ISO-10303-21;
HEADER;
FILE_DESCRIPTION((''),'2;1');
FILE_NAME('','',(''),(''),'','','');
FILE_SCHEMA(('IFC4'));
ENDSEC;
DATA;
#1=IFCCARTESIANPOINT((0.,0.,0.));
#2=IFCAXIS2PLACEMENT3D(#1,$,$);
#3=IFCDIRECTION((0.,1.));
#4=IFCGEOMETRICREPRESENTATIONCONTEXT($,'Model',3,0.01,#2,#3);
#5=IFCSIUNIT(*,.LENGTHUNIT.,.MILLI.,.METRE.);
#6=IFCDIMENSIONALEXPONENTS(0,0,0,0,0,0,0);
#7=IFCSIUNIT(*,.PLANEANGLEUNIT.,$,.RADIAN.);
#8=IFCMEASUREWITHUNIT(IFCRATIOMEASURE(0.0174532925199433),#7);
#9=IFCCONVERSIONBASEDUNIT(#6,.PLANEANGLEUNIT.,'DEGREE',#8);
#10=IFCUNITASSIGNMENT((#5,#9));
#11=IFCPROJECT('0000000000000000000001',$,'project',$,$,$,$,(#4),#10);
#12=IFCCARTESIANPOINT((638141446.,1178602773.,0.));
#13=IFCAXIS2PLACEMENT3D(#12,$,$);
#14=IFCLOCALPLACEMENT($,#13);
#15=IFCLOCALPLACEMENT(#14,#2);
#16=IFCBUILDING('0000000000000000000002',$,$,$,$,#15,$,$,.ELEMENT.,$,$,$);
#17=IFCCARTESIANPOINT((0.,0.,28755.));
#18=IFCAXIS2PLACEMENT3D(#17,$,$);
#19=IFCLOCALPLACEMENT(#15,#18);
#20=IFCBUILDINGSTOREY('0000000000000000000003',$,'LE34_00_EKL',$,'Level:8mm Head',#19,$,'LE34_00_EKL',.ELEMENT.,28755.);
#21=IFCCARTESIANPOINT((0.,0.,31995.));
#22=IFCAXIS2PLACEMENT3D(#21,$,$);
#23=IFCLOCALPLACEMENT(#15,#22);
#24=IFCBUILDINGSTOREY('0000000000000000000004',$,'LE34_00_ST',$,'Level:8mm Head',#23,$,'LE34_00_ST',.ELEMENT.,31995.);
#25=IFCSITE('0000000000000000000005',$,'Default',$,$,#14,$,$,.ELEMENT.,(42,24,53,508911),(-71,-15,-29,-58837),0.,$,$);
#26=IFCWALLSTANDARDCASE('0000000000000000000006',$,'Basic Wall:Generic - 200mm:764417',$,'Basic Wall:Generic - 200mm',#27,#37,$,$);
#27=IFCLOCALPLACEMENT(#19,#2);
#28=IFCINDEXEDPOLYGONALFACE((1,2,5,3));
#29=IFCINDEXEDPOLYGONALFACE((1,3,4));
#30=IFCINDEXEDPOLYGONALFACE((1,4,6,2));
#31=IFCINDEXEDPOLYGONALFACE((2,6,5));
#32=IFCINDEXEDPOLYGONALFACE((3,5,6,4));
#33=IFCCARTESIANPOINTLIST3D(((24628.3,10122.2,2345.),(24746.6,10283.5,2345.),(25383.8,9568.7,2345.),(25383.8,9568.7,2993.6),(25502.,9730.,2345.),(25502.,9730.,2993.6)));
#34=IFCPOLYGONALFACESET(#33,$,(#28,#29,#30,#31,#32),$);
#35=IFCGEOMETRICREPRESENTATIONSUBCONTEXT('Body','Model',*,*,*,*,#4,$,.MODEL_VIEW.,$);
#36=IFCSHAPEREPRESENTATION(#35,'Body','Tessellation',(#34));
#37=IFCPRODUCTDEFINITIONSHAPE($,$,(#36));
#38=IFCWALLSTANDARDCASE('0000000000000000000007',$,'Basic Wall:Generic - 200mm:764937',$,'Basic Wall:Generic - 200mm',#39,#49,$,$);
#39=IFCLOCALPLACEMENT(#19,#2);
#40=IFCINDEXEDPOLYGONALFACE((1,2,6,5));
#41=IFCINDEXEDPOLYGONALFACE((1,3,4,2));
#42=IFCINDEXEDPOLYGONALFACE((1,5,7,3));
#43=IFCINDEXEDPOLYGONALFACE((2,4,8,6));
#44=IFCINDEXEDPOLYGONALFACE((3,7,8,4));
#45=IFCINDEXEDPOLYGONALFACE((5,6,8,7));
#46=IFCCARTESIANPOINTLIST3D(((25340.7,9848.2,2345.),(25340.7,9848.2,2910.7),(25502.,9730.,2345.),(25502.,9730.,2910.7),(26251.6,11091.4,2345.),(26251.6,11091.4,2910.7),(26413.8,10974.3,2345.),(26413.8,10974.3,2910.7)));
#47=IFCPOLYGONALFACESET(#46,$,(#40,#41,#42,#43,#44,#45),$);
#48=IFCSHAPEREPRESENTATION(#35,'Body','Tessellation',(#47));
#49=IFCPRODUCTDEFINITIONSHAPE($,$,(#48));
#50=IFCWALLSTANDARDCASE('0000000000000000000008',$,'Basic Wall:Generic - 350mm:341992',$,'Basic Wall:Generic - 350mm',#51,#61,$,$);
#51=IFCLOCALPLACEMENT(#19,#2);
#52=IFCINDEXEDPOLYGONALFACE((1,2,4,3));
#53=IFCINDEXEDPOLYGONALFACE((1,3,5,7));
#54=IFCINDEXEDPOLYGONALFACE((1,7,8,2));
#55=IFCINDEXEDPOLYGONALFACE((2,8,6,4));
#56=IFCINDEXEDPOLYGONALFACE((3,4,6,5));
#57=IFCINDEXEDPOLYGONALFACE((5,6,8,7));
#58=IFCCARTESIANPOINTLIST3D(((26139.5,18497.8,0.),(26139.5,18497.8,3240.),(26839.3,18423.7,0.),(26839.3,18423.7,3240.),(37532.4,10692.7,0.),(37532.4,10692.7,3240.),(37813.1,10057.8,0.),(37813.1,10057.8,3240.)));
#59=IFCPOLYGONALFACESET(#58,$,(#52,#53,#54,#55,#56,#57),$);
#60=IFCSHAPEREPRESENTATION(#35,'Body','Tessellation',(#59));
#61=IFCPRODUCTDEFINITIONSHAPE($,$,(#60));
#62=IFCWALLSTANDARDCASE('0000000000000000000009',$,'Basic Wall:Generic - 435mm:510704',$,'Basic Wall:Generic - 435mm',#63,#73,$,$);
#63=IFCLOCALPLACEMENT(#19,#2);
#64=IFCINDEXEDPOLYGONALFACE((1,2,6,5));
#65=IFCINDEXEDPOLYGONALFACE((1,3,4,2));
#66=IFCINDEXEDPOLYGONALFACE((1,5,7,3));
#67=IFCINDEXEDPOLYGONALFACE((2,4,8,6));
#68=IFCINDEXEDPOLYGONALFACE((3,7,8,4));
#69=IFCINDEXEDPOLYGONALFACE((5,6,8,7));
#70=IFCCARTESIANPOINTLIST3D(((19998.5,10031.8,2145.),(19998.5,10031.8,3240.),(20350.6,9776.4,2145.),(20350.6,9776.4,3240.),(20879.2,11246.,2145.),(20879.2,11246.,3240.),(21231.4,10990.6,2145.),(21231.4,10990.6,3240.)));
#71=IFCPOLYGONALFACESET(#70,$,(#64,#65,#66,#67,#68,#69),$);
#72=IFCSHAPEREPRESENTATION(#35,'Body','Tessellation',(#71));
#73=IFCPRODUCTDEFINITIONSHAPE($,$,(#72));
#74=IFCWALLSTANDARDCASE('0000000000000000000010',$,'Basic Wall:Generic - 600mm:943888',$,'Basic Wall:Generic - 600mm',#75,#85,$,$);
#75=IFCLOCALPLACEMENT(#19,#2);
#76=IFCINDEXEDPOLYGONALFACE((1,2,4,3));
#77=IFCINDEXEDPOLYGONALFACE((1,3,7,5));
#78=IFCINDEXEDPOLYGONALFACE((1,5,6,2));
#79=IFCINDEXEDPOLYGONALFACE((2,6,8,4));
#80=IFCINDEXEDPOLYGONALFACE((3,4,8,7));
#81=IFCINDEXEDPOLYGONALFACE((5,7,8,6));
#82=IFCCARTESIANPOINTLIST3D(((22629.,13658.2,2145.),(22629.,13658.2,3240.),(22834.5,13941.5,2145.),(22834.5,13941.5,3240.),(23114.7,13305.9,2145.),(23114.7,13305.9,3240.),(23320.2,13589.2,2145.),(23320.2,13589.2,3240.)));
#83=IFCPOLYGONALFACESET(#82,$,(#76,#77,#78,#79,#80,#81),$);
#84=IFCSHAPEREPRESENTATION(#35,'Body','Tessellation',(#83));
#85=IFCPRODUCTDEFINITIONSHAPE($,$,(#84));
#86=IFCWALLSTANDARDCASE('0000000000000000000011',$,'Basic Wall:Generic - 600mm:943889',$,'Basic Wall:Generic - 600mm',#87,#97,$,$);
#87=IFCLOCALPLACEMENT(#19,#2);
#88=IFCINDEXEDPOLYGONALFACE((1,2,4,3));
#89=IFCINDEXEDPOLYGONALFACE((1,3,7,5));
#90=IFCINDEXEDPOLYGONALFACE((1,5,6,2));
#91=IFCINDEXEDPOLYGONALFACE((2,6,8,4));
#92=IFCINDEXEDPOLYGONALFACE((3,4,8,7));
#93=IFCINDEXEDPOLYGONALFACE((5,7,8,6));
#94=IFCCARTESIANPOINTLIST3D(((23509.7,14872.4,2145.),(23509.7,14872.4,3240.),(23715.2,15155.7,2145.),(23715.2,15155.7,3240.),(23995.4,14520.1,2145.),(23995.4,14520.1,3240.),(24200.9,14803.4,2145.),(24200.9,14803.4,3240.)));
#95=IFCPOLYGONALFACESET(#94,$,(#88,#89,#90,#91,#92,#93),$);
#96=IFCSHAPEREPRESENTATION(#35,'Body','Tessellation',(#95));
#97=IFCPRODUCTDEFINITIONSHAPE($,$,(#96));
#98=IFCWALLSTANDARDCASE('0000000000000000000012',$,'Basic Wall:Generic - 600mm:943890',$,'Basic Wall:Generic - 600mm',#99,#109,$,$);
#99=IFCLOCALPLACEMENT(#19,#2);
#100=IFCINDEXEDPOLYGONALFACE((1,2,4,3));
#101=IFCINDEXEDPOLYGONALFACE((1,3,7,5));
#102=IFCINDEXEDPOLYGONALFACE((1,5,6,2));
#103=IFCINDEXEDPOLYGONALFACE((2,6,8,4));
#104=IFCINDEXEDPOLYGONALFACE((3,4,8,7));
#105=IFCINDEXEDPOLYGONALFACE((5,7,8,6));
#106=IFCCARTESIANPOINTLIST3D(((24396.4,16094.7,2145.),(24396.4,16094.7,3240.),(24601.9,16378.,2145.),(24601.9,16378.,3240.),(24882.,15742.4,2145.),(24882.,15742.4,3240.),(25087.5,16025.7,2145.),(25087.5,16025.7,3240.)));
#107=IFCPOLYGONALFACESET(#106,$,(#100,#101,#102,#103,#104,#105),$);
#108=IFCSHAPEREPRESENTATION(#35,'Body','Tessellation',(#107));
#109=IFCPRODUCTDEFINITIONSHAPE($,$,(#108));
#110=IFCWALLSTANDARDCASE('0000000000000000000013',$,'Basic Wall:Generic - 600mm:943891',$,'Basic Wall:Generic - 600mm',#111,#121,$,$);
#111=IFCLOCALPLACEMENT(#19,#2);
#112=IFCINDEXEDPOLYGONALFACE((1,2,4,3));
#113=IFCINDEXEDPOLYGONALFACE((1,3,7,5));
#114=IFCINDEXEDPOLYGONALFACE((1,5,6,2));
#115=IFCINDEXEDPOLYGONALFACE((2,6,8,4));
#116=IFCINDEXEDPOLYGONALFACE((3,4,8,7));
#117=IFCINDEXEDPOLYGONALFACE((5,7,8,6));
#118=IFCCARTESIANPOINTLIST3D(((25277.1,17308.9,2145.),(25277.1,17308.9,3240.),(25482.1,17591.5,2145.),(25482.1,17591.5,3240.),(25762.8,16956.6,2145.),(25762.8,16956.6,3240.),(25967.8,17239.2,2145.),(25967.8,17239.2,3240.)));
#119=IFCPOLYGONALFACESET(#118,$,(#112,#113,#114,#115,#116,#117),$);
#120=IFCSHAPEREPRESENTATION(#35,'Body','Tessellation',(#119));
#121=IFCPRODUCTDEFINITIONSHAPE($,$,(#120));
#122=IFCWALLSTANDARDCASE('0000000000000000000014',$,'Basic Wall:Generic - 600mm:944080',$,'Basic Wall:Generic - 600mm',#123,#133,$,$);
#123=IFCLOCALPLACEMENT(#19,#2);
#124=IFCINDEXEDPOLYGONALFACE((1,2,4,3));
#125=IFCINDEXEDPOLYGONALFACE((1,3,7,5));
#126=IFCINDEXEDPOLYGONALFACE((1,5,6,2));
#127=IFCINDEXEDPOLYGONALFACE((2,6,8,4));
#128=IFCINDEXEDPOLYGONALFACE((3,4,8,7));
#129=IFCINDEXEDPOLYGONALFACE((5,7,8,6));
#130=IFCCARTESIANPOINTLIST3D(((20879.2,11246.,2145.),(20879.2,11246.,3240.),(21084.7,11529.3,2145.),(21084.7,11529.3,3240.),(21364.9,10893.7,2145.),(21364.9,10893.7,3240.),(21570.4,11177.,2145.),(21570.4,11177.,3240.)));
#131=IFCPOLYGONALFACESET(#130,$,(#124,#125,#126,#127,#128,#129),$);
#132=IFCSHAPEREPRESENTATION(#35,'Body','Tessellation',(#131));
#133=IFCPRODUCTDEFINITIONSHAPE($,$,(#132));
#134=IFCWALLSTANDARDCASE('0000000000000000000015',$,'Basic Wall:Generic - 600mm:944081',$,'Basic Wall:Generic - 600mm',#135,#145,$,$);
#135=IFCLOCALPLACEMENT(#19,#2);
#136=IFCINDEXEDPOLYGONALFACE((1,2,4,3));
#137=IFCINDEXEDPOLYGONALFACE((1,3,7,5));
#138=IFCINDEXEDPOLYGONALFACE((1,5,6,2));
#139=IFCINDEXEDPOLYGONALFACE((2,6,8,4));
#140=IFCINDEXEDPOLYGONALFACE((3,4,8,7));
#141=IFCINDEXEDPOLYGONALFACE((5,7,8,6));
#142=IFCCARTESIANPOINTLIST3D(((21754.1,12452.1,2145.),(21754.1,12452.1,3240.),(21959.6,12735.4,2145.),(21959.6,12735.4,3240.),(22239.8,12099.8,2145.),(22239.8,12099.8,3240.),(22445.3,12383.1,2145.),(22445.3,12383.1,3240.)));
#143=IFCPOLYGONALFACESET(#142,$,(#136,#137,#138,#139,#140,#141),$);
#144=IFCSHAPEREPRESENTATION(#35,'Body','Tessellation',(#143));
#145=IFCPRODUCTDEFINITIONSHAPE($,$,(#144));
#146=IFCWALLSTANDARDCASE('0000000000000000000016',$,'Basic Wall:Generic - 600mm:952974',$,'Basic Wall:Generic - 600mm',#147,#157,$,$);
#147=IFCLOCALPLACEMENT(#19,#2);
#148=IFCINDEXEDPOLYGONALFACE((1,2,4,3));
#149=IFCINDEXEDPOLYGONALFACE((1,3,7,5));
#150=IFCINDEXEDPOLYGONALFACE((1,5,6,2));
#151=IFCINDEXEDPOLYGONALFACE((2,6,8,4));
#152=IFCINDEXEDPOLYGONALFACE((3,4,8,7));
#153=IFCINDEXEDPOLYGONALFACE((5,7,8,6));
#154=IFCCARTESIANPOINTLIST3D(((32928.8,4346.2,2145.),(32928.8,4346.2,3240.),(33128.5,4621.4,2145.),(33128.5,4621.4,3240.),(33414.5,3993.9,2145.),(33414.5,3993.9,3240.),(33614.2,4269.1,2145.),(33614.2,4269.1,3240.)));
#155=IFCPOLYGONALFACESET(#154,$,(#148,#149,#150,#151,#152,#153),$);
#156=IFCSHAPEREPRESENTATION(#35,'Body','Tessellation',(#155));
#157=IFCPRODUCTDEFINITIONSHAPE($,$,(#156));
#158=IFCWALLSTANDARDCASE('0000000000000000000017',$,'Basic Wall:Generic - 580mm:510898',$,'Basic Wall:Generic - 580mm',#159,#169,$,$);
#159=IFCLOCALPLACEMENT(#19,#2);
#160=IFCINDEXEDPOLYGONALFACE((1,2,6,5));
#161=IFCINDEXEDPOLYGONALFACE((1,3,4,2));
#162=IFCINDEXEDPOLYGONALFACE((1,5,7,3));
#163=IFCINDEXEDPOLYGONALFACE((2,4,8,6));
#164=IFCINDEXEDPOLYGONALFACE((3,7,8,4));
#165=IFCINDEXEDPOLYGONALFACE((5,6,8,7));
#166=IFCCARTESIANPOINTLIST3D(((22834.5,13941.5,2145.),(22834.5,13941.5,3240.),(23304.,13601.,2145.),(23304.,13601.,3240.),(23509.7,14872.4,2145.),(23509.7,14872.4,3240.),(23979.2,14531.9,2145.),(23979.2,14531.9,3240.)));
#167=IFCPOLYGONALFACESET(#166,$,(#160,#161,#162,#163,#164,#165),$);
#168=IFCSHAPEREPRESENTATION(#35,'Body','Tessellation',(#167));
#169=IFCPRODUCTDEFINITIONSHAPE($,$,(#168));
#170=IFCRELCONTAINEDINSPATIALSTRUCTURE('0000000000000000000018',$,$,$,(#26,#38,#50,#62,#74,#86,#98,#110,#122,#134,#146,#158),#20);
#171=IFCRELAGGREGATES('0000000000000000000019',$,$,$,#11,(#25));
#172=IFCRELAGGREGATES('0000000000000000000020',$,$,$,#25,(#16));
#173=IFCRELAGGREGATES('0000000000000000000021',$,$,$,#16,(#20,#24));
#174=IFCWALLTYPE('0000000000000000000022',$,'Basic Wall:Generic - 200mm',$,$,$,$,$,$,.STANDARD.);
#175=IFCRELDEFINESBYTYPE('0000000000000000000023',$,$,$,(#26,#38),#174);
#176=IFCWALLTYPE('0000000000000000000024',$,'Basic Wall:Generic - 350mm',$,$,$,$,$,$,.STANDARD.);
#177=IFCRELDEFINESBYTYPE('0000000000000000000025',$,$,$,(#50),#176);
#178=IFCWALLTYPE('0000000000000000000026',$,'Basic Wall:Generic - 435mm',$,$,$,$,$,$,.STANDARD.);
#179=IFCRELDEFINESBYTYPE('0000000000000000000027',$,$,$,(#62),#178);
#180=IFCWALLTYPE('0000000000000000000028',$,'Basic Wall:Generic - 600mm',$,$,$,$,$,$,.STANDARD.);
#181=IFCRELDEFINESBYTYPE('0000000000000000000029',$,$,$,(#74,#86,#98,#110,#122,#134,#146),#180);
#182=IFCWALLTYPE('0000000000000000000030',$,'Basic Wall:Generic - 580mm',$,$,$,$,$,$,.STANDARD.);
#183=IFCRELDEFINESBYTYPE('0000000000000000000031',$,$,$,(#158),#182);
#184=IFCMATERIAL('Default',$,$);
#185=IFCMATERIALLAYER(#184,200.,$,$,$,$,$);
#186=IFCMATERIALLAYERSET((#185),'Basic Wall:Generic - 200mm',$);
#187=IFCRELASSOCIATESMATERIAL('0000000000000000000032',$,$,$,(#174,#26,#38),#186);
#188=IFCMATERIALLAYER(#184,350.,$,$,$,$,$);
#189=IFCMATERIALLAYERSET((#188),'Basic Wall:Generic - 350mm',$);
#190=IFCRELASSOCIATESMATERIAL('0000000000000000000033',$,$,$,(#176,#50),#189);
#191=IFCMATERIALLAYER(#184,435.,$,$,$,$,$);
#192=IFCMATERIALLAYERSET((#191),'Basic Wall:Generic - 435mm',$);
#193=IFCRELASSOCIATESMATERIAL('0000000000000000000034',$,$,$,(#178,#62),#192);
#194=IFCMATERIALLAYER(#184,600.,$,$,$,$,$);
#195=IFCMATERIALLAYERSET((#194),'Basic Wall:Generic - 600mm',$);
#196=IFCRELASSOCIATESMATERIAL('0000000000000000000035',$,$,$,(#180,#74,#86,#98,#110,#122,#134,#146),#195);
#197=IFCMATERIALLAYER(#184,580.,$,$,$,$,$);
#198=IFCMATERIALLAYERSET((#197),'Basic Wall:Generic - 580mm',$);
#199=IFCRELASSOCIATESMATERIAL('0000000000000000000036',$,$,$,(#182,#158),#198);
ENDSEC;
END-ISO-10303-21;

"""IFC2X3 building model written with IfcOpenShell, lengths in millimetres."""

from ifc_helpers import new_model, entity, si_unit, converted_unit, direction, frame, frame_2d, origin, place, context, subcontext, project, spatial, polyline, rectangle, outline, extrude, clip, halfspace, material, layer, layer_set, layer_usage, type_object, element, save


model = new_model("IFC2X3")

# Units and contexts
model_context = context("Model", 3, precision=0.01, world=origin(), true_north=direction((0.0, 1.0)))
body_context = subcontext(model_context, "Body", "Model", "MODEL_VIEW")
ifc_project = project(units=[si_unit("LENGTHUNIT", "METRE", prefix="MILLI"), converted_unit("PLANEANGLEUNIT", "DEGREE", entity("IfcRatioMeasure", 0.0174532925199433), si_unit("PLANEANGLEUNIT", "RADIAN"), dimensions=[0, 0, 0, 0, 0, 0, 0])], contexts=[model_context])

# Site, building, storey
site_placement = place(None, frame((638141446.0, 1178602773.0, 0.0)))
site = spatial("IfcSite", under=ifc_project, at=site_placement, Name="Default", CompositionType="ELEMENT", RefLatitude=(42, 24, 53, 508911), RefLongitude=(-71, -15, -29, -58837), RefElevation=0.0)
building_placement = place(site_placement, origin())
building = spatial("IfcBuilding", under=site, at=building_placement, CompositionType="ELEMENT")
storey_1_placement = place(building_placement, frame((0.0, 0.0, 28755.0)))
storey_1 = spatial("IfcBuildingStorey", under=building, at=storey_1_placement, Name="LE34_00_EKL", ObjectType="Level:8mm Head", LongName="LE34_00_EKL", CompositionType="ELEMENT", Elevation=28755.0)

# Shared definitions
ifc_material_1 = material(Name="Default")

# Shared definitions
storey_2_placement = place(building_placement, frame((0.0, 0.0, 31995.0)))
storey_2 = spatial("IfcBuildingStorey", under=building, at=storey_2_placement, Name="LE34_00_ST", ObjectType="Level:8mm Head", LongName="LE34_00_ST", CompositionType="ELEMENT", Elevation=31995.0)

# Walls
ifc_layer_1 = layer(ifc_material_1, 200.0)
ifc_layer_set_1 = layer_set([ifc_layer_1], Name="Basic Wall:Generic - 200mm")
wall_type_1 = type_object("IfcWallType", Name="Basic Wall:Generic - 200mm", PredefinedType="STANDARD", material=ifc_layer_set_1)
ifc_layer_usage_1 = layer_usage(ifc_layer_set_1, "AXIS2", "NEGATIVE", 100.0)
wall_1_placement = place(storey_1_placement, frame((25442.9, 9649.3, 2345.0), z_axis=(0.0, 0.0, 1.0), x_axis=(-0.806629, 0.591058, 0.0)))
element("IfcWallStandardCase", 1, at=wall_1_placement, inside=storey_1, type_object=wall_type_1, material=ifc_layer_usage_1, Name="Basic Wall:Generic - 200mm:764417", ObjectType="Basic Wall:Generic - 200mm", context=body_context, shape_type="Clipping", body=[
    clip(extrude(rectangle(XDim=936.6, YDim=200.0, at=frame_2d((468.3, 0.0), x_axis=(-1.0, 0.0))), origin(), (0.0, 0.0, 1.0), 648.6), halfspace(frame((0.0, -100.0, 648.6), z_axis=(0.569368, 0.0, 0.822083), x_axis=(0.0, 1.0, 0.0)), False)),
])
ifc_layer_usage_2 = layer_usage(ifc_layer_set_1, "AXIS2", "POSITIVE", -100.0)
wall_2_placement = place(storey_1_placement, frame((26333.1, 11033.4, 2345.0), z_axis=(0.0, 0.0, 1.0), x_axis=(-0.591058, -0.806629, 0.0)))
element("IfcWallStandardCase", 2, at=wall_2_placement, inside=storey_1, type_object=wall_type_1, material=ifc_layer_usage_2, Name="Basic Wall:Generic - 200mm:764937", ObjectType="Basic Wall:Generic - 200mm", context=body_context, shape_type="SweptSolid", body=[
    extrude(outline(polyline([(1542.6, -100.0), (1542.6, 100.0), (0.0, 100.0), (1.4, -100.0), (1542.6, -100.0)])), origin(), (0.0, 0.0, 1.0), 565.7),
])
ifc_layer_2 = layer(ifc_material_1, 350.0)
ifc_layer_set_2 = layer_set([ifc_layer_2], Name="Basic Wall:Generic - 350mm")
ifc_layer_usage_3 = layer_usage(ifc_layer_set_2, "AXIS2", "POSITIVE", -175.0)
wall_type_2 = type_object("IfcWallType", Name="Basic Wall:Generic - 350mm", PredefinedType="STANDARD", material=ifc_layer_set_2)
wall_3_placement = place(storey_1_placement, frame((37915.7, 10199.6, 0.0), z_axis=(0.0, 0.0, 1.0), x_axis=(-0.810383, 0.585901, 0.0)))
element("IfcWallStandardCase", 3, at=wall_3_placement, inside=storey_1, type_object=wall_type_2, material=ifc_layer_usage_3, Name="Basic Wall:Generic - 350mm:341992", ObjectType="Basic Wall:Generic - 350mm", context=body_context, shape_type="SweptSolid", body=[
    extrude(outline(polyline([(13794.6, -175.0), (14405.1, 175.0), (0.0, 175.0), (599.5, -175.0), (13794.6, -175.0)])), origin(), (0.0, 0.0, 1.0), 3240.0),
])
ifc_layer_3 = layer(ifc_material_1, 435.0)
ifc_layer_set_3 = layer_set([ifc_layer_3], Name="Basic Wall:Generic - 435mm")
ifc_layer_usage_4 = layer_usage(ifc_layer_set_3, "AXIS2", "NEGATIVE", 217.5)
wall_type_3 = type_object("IfcWallType", Name="Basic Wall:Generic - 435mm", PredefinedType="STANDARD", material=ifc_layer_set_3)
wall_4_placement = place(storey_1_placement, frame((20174.6, 9904.1, 2145.0), z_axis=(0.0, 0.0, 1.0), x_axis=(0.587164, 0.809468, 0.0)))
element("IfcWallStandardCase", 4, at=wall_4_placement, inside=storey_1, type_object=wall_type_3, material=ifc_layer_usage_4, Name="Basic Wall:Generic - 435mm:510704", ObjectType="Basic Wall:Generic - 435mm", context=body_context, shape_type="SweptSolid", body=[
    extrude(rectangle(XDim=1500.0, YDim=435.0, at=frame_2d((750.0, 0.0), x_axis=(-1.0, 0.0))), origin(), (0.0, 0.0, 1.0), 1095.0),
])
ifc_layer_4 = layer(ifc_material_1, 600.0)
ifc_layer_set_4 = layer_set([ifc_layer_4], Name="Basic Wall:Generic - 600mm")
ifc_layer_usage_5 = layer_usage(ifc_layer_set_4, "AXIS2", "NEGATIVE", 300.0)
wall_type_4 = type_object("IfcWallType", Name="Basic Wall:Generic - 600mm", PredefinedType="STANDARD", material=ifc_layer_set_4)
wall_5_placement = place(storey_1_placement, frame((22871.8, 13482.1, 2145.0), z_axis=(0.0, 0.0, 1.0), x_axis=(0.587164, 0.809468, 0.0)))
element("IfcWallStandardCase", 5, at=wall_5_placement, inside=storey_1, type_object=wall_type_4, material=ifc_layer_usage_5, Name="Basic Wall:Generic - 600mm:943888", ObjectType="Basic Wall:Generic - 600mm", context=body_context, shape_type="SweptSolid", body=[
    extrude(rectangle(XDim=350.0, YDim=600.0, at=frame_2d((175.0, 0.0), x_axis=(-1.0, 0.0))), origin(), (0.0, 0.0, 1.0), 1095.0),
])
ifc_layer_usage_6 = layer_usage(ifc_layer_set_4, "AXIS2", "NEGATIVE", 300.0)
wall_6_placement = place(storey_1_placement, frame((23752.6, 14696.3, 2145.0), z_axis=(0.0, 0.0, 1.0), x_axis=(0.587164, 0.809468, 0.0)))
element("IfcWallStandardCase", 6, at=wall_6_placement, inside=storey_1, type_object=wall_type_4, material=ifc_layer_usage_6, Name="Basic Wall:Generic - 600mm:943889", ObjectType="Basic Wall:Generic - 600mm", context=body_context, shape_type="SweptSolid", body=[
    extrude(rectangle(XDim=350.0, YDim=600.0, at=frame_2d((175.0, 0.0), x_axis=(-1.0, 0.0))), origin(), (0.0, 0.0, 1.0), 1095.0),
])
ifc_layer_usage_7 = layer_usage(ifc_layer_set_4, "AXIS2", "NEGATIVE", 300.0)
wall_7_placement = place(storey_1_placement, frame((24639.2, 15918.6, 2145.0), z_axis=(0.0, 0.0, 1.0), x_axis=(0.587164, 0.809468, 0.0)))
element("IfcWallStandardCase", 7, at=wall_7_placement, inside=storey_1, type_object=wall_type_4, material=ifc_layer_usage_7, Name="Basic Wall:Generic - 600mm:943890", ObjectType="Basic Wall:Generic - 600mm", context=body_context, shape_type="SweptSolid", body=[
    extrude(rectangle(XDim=350.0, YDim=600.0, at=frame_2d((175.0, 0.0), x_axis=(-1.0, 0.0))), origin(), (0.0, 0.0, 1.0), 1095.0),
])
ifc_layer_usage_8 = layer_usage(ifc_layer_set_4, "AXIS2", "NEGATIVE", 300.0)
wall_8_placement = place(storey_1_placement, frame((25519.9, 17132.8, 2145.0), z_axis=(0.0, 0.0, 1.0), x_axis=(0.587164, 0.809468, 0.0)))
element("IfcWallStandardCase", 8, at=wall_8_placement, inside=storey_1, type_object=wall_type_4, material=ifc_layer_usage_8, Name="Basic Wall:Generic - 600mm:943891", ObjectType="Basic Wall:Generic - 600mm", context=body_context, shape_type="SweptSolid", body=[
    extrude(rectangle(XDim=349.1, YDim=600.0, at=frame_2d((174.5, 0.0), x_axis=(-1.0, 0.0))), origin(), (0.0, 0.0, 1.0), 1095.0),
])
ifc_layer_usage_9 = layer_usage(ifc_layer_set_4, "AXIS2", "NEGATIVE", 300.0)
wall_9_placement = place(storey_1_placement, frame((21122.1, 11069.9, 2145.0), z_axis=(0.0, 0.0, 1.0), x_axis=(0.587164, 0.809468, 0.0)))
element("IfcWallStandardCase", 9, at=wall_9_placement, inside=storey_1, type_object=wall_type_4, material=ifc_layer_usage_9, Name="Basic Wall:Generic - 600mm:944080", ObjectType="Basic Wall:Generic - 600mm", context=body_context, shape_type="SweptSolid", body=[
    extrude(rectangle(XDim=350.0, YDim=600.0, at=frame_2d((175.0, 0.0), x_axis=(-1.0, 0.0))), origin(), (0.0, 0.0, 1.0), 1095.0),
])
ifc_layer_usage_10 = layer_usage(ifc_layer_set_4, "AXIS2", "NEGATIVE", 300.0)
wall_10_placement = place(storey_1_placement, frame((21997.0, 12276.0, 2145.0), z_axis=(0.0, 0.0, 1.0), x_axis=(0.587164, 0.809468, 0.0)))
element("IfcWallStandardCase", 10, at=wall_10_placement, inside=storey_1, type_object=wall_type_4, material=ifc_layer_usage_10, Name="Basic Wall:Generic - 600mm:944081", ObjectType="Basic Wall:Generic - 600mm", context=body_context, shape_type="SweptSolid", body=[
    extrude(rectangle(XDim=350.0, YDim=600.0, at=frame_2d((175.0, 0.0), x_axis=(-1.0, 0.0))), origin(), (0.0, 0.0, 1.0), 1095.0),
])
ifc_layer_usage_11 = layer_usage(ifc_layer_set_4, "AXIS2", "NEGATIVE", 300.0)
wall_11_placement = place(storey_1_placement, frame((33371.3, 4445.2, 2145.0), z_axis=(0.0, 0.0, 1.0), x_axis=(-0.587164, -0.809468, 0.0)))
element("IfcWallStandardCase", 11, at=wall_11_placement, inside=storey_1, type_object=wall_type_4, material=ifc_layer_usage_11, Name="Basic Wall:Generic - 600mm:952974", ObjectType="Basic Wall:Generic - 600mm", context=body_context, shape_type="SweptSolid", body=[
    extrude(rectangle(XDim=340.0, YDim=600.0, at=frame_2d((170.0, 0.0), x_axis=(-1.0, 0.0))), origin(), (0.0, 0.0, 1.0), 1095.0),
])
ifc_layer_5 = layer(ifc_material_1, 580.0)
ifc_layer_set_5 = layer_set([ifc_layer_5], Name="Basic Wall:Generic - 580mm")
ifc_layer_usage_12 = layer_usage(ifc_layer_set_5, "AXIS2", "NEGATIVE", 290.0)
wall_type_5 = type_object("IfcWallType", Name="Basic Wall:Generic - 580mm", PredefinedType="STANDARD", material=ifc_layer_set_5)
wall_12_placement = place(storey_1_placement, frame((23069.2, 13771.3, 2145.0), z_axis=(0.0, 0.0, 1.0), x_axis=(0.587164, 0.809468, 0.0)))
element("IfcWallStandardCase", 12, at=wall_12_placement, inside=storey_1, type_object=wall_type_5, material=ifc_layer_usage_12, Name="Basic Wall:Generic - 580mm:510898", ObjectType="Basic Wall:Generic - 580mm", context=body_context, shape_type="SweptSolid", body=[
    extrude(rectangle(XDim=1150.0, YDim=580.0, at=frame_2d((575.0, 0.0), x_axis=(-1.0, 0.0))), origin(), (0.0, 0.0, 1.0), 1095.0),
])

save(model, "model.ifc")
